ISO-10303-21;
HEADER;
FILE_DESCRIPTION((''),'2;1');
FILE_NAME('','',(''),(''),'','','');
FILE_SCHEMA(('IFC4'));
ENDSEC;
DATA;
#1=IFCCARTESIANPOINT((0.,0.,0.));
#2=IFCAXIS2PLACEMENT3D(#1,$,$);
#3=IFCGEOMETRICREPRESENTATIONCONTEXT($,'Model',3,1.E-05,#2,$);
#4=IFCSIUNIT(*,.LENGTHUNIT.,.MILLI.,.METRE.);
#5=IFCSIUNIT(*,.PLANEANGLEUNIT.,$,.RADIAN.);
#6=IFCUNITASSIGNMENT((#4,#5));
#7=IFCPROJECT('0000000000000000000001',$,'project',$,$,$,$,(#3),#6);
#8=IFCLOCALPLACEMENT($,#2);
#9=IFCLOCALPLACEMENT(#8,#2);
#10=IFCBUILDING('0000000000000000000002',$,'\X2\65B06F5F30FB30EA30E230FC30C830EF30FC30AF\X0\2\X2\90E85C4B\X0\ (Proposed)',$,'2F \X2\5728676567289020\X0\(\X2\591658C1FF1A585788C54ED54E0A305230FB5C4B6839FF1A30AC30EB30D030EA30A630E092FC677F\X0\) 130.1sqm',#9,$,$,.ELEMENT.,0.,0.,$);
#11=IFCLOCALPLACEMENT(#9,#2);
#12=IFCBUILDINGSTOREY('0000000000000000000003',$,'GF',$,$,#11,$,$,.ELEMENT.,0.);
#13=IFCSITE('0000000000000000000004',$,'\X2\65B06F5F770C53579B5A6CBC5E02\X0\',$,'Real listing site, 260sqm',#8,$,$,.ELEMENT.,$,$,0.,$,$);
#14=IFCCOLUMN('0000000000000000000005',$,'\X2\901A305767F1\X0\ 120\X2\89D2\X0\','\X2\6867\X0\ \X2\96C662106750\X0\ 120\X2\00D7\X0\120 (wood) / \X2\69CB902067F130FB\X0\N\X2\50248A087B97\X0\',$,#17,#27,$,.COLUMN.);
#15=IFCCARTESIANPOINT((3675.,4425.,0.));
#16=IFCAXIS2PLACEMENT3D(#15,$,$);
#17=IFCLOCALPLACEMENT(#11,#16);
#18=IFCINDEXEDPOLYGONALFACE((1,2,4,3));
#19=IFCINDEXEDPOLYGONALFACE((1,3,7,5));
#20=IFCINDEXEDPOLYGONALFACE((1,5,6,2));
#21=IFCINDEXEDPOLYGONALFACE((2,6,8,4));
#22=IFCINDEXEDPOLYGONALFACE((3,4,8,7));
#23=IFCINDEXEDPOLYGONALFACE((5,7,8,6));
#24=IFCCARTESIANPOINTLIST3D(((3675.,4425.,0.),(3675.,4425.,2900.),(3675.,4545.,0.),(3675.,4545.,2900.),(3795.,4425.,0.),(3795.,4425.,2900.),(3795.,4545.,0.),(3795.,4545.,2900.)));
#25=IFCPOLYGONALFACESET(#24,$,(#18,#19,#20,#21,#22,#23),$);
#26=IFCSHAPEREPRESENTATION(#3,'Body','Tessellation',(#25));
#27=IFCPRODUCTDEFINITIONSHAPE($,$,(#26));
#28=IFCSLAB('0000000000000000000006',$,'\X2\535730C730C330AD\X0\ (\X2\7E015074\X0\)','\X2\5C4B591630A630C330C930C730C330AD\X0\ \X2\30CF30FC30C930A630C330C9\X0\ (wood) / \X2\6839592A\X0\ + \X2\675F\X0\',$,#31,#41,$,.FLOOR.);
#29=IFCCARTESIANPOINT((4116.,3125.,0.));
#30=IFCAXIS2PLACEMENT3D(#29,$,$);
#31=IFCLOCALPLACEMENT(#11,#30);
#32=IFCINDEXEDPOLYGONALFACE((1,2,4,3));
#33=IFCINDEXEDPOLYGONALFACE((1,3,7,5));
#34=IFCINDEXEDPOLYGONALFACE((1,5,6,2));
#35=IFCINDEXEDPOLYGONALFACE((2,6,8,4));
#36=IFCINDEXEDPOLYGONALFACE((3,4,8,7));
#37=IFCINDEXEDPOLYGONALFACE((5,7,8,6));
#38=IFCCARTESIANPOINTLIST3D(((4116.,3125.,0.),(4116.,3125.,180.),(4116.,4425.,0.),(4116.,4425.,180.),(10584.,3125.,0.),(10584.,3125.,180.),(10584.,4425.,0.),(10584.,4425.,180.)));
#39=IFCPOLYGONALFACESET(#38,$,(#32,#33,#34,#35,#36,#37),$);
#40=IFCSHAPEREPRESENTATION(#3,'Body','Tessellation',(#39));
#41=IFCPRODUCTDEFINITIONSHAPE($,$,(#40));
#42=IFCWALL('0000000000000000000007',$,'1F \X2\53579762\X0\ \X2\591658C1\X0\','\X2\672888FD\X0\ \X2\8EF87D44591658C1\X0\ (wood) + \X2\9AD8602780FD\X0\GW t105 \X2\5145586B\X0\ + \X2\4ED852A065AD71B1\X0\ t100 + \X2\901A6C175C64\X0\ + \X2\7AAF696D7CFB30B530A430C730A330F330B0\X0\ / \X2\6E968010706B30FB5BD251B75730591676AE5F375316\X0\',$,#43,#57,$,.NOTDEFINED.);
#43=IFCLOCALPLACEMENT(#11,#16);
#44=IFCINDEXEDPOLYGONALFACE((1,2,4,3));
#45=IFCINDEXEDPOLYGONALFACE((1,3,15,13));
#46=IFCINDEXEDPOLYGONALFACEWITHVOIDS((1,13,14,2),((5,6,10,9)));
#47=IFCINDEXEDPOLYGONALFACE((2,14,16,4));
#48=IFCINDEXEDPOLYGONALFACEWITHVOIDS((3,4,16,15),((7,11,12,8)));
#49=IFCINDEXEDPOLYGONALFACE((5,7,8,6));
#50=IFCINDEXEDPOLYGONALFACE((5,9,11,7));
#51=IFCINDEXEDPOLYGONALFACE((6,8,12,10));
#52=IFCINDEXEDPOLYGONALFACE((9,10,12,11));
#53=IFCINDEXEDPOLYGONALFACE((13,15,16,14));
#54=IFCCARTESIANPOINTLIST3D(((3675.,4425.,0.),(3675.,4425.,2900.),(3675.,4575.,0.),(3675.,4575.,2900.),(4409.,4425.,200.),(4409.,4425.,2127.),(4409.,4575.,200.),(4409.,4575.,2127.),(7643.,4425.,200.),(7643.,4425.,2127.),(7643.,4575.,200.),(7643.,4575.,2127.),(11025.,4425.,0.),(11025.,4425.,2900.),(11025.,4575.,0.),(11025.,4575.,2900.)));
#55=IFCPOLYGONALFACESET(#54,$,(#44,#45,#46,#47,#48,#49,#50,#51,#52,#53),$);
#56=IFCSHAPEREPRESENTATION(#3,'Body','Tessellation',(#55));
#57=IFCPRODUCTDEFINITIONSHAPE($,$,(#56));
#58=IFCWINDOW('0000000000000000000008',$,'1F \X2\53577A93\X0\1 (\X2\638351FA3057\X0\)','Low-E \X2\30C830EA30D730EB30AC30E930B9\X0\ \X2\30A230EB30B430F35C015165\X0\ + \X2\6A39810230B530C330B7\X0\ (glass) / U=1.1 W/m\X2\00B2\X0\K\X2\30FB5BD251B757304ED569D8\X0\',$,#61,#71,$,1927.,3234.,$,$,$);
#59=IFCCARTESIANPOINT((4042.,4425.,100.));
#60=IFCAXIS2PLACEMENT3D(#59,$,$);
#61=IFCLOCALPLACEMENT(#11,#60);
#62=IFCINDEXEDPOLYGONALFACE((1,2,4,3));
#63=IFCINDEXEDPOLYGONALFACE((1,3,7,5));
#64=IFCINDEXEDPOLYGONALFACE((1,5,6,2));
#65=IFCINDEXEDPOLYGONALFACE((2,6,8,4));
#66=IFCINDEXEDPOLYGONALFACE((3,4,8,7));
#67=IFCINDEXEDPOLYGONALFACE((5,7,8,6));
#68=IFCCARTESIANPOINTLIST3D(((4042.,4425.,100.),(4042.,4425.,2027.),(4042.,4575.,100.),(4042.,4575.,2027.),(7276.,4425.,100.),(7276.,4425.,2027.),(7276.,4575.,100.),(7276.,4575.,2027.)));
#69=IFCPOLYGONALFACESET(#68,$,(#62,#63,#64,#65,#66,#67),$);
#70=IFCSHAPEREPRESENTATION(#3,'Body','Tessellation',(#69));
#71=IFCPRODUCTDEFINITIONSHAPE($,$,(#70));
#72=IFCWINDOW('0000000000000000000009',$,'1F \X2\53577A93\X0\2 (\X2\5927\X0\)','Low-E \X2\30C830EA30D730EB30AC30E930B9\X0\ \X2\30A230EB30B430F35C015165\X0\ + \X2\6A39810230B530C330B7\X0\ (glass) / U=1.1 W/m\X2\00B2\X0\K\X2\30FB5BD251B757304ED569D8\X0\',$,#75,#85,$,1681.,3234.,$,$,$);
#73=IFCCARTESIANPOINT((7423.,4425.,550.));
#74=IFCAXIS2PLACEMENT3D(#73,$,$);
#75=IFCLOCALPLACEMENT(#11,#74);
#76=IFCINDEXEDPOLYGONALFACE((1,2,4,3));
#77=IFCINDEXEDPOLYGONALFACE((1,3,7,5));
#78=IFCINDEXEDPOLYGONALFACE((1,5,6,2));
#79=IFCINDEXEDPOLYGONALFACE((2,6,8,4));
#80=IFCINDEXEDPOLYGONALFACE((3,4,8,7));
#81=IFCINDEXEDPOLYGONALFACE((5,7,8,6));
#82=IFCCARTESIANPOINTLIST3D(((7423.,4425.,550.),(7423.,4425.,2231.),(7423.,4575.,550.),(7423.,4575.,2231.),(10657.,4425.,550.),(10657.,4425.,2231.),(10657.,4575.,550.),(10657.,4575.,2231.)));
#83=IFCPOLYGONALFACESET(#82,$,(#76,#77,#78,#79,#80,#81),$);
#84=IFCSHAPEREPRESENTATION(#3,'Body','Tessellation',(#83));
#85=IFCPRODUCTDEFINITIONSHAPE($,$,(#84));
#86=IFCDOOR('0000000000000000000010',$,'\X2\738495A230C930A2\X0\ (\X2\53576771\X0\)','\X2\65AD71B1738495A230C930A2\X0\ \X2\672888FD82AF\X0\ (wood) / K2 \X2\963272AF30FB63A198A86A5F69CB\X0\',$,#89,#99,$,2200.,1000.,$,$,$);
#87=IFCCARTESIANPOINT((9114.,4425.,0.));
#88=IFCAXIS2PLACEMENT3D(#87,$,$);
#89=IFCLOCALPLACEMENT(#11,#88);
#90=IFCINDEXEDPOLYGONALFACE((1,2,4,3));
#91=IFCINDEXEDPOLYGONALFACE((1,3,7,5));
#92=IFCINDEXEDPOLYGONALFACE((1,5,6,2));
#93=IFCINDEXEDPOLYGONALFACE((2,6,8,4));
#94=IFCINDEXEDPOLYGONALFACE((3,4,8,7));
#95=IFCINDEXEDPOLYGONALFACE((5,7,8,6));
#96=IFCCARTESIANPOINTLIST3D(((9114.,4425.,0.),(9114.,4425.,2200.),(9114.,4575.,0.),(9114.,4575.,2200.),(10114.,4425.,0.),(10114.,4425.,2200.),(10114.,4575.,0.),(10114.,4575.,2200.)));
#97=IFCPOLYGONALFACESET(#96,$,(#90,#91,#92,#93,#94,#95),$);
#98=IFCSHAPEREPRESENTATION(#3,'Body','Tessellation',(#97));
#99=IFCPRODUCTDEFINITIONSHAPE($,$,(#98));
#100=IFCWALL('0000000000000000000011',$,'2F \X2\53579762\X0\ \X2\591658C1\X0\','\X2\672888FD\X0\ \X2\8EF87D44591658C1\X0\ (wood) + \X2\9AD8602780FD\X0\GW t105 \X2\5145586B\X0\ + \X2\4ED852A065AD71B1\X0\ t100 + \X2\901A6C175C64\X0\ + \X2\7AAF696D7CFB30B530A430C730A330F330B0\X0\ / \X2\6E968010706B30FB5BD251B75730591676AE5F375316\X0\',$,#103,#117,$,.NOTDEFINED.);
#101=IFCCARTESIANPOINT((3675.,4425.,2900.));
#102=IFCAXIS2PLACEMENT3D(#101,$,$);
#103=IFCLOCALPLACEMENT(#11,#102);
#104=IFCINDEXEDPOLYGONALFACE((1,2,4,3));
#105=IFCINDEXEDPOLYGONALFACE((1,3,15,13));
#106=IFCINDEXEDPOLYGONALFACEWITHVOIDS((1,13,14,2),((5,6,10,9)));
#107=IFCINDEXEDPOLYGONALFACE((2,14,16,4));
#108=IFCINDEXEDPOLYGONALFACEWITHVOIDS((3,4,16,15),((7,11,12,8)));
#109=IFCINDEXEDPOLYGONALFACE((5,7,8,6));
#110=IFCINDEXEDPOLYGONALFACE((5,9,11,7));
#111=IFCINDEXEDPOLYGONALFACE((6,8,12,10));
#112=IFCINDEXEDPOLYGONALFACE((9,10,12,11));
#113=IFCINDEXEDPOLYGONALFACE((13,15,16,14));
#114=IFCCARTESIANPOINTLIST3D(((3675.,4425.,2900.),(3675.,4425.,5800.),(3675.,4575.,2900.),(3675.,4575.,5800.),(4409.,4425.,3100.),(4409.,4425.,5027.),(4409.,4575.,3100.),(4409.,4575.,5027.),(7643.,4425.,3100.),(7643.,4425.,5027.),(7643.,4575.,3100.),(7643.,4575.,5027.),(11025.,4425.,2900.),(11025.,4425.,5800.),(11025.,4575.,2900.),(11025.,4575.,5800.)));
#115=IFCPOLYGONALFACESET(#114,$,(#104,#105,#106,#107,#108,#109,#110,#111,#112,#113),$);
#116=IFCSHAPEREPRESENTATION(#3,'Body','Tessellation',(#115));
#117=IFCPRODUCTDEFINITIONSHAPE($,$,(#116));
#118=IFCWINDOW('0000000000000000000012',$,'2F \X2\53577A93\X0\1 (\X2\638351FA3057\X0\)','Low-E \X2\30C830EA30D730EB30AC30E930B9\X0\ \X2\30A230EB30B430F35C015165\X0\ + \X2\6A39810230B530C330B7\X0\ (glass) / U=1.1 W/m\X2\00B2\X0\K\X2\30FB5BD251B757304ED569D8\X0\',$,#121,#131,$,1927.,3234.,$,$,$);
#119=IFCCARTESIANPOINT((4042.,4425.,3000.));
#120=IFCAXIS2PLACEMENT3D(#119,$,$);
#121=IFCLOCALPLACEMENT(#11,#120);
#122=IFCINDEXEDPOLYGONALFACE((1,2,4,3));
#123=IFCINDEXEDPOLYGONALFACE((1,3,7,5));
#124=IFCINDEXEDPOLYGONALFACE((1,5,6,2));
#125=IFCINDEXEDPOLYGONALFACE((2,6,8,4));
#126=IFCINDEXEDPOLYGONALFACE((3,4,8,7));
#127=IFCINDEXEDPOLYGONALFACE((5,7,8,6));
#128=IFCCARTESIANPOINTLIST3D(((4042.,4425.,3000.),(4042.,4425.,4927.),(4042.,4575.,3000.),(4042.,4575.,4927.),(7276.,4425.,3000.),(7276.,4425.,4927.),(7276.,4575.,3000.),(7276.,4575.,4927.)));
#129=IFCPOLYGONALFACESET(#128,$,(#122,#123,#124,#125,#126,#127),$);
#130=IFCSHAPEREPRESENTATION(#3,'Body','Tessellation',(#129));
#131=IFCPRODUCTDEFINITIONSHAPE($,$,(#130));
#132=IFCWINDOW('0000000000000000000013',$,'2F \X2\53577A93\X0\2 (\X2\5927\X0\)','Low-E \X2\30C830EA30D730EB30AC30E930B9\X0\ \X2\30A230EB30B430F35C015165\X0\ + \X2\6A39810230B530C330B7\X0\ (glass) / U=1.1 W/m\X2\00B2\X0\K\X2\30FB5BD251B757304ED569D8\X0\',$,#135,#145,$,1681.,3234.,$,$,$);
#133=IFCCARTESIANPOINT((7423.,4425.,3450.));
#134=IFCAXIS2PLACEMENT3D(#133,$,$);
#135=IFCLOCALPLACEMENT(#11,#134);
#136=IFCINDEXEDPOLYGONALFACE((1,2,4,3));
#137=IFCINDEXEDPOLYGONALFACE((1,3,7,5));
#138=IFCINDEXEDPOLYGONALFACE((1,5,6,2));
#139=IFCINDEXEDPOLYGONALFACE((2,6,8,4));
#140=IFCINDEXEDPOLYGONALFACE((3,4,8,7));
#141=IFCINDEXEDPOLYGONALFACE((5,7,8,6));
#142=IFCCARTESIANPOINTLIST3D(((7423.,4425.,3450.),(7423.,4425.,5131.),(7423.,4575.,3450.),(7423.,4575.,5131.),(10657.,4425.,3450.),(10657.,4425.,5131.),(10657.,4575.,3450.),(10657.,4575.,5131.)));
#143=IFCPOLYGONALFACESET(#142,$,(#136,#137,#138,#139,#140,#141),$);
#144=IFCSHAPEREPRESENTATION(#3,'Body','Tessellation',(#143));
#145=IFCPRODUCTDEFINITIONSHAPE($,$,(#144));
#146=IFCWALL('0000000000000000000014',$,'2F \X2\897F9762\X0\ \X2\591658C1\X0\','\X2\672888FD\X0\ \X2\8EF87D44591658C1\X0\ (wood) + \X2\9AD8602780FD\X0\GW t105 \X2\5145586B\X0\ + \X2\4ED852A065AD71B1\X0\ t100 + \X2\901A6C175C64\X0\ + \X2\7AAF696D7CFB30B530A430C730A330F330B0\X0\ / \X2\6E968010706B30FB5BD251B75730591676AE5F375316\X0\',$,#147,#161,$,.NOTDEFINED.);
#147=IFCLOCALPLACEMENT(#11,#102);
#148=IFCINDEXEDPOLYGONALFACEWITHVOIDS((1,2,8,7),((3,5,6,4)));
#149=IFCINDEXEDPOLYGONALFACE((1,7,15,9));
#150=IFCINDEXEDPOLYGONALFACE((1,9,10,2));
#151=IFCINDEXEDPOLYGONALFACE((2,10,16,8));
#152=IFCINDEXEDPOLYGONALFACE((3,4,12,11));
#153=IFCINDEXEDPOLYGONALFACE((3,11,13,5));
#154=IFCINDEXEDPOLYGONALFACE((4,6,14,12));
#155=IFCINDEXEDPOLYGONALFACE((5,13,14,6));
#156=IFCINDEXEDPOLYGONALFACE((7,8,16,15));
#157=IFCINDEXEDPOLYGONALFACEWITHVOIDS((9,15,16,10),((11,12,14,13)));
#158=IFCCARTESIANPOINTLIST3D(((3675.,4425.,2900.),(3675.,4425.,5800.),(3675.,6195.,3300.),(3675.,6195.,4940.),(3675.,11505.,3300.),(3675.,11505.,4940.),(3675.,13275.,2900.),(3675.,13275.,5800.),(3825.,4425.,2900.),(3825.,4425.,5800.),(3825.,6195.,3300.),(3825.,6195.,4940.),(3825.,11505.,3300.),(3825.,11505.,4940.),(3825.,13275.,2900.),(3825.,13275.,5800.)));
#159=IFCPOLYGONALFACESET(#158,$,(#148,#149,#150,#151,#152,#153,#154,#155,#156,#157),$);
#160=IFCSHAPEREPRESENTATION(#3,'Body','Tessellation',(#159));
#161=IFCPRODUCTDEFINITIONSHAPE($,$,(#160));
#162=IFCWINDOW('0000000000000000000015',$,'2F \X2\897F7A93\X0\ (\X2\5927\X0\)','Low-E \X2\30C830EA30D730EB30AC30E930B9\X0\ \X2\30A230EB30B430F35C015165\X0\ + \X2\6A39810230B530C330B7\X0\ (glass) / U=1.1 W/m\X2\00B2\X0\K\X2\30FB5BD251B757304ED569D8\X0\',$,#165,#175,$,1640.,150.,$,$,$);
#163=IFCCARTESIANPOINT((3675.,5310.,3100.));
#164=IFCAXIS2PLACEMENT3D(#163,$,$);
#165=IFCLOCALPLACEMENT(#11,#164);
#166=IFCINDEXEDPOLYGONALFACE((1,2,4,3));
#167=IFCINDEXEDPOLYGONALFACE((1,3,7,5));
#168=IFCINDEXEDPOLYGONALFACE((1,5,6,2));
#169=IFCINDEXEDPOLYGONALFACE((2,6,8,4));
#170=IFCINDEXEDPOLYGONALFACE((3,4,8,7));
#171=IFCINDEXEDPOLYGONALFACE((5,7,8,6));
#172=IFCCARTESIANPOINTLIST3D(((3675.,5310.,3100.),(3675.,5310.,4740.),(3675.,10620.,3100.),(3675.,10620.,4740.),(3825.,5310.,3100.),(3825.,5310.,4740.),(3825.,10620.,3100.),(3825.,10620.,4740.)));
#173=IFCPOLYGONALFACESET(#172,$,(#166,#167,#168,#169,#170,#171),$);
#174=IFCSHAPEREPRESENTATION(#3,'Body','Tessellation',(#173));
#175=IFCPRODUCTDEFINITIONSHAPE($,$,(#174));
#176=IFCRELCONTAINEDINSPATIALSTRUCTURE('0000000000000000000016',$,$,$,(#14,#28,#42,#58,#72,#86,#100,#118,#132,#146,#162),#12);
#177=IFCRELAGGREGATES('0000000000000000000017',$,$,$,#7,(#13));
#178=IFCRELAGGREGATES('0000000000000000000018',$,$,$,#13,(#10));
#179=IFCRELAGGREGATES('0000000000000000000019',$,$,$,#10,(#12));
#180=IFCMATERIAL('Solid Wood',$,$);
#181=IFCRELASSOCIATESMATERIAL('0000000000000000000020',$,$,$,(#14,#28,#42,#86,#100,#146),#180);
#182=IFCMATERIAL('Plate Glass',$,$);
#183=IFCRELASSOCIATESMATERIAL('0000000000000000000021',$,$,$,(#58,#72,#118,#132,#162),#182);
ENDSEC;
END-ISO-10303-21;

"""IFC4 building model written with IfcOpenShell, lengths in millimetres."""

from ifc_helpers import new_model, si_unit, frame, frame_2d, origin, place, context, project, spatial, rectangle, extrude, material, element, fill, save


model = new_model("IFC4")

# Units and contexts
model_context = context("Model", 3, precision=1e-05, world=origin())
ifc_project = project(units=[si_unit("LENGTHUNIT", "METRE", prefix="MILLI"), si_unit("PLANEANGLEUNIT", "RADIAN")], contexts=[model_context])

# Site, building, storey
site_placement = place(None, origin())
site = spatial("IfcSite", under=ifc_project, at=site_placement, Name="新潟県南魚沼市", ObjectType="Real listing site, 260sqm", CompositionType="ELEMENT", RefElevation=0.0)
building_placement = place(site_placement, origin())
building = spatial("IfcBuilding", under=site, at=building_placement, Name="新潟・リモートワーク2部屋 (Proposed)", ObjectType="2F 在来木造(外壁：塗装仕上げ・屋根：ガルバリウム鋼板) 130.1sqm", CompositionType="ELEMENT", ElevationOfRefHeight=0.0, ElevationOfTerrain=0.0)
storey_placement = place(building_placement, origin())
storey = spatial("IfcBuildingStorey", under=building, at=storey_placement, Name="GF", CompositionType="ELEMENT", Elevation=0.0)

# Column
ifc_material_1 = material(Name="Solid Wood")
column_placement = place(storey_placement, frame((3675.0, 4425.0, 0.0)))
element("IfcColumn", 1, at=column_placement, inside=storey, material=ifc_material_1, Name="通し柱 120角", Description="桧 集成材 120×120 (wood) / 構造柱・N値計算", PredefinedType="COLUMN", context=model_context, shape_type="SweptSolid", body=[
    extrude(rectangle(XDim=120.0, YDim=120.0, at=frame_2d((60.0, 60.0))), frame((3675.0, 4425.0, 0.0)), (0.0, 0.0, 1.0), 2900.0),
])

# Slab
slab_1_placement = place(storey_placement, frame((4116.0, 3125.0, 0.0)))
element("IfcSlab", 2, at=slab_1_placement, inside=storey, material=ifc_material_1, Name="南デッキ (縁側)", Description="屋外ウッドデッキ ハードウッド (wood) / 根太 + 束", PredefinedType="FLOOR", context=model_context, shape_type="SweptSolid", body=[
    extrude(rectangle(XDim=6468.0, YDim=1300.0, at=frame_2d((3234.0, 650.0))), frame((4116.0, 3125.0, 0.0)), (0.0, 0.0, 1.0), 180.0),
])

# Wall, openings, windows, door
wall_1_placement = place(storey_placement, frame((3675.0, 4425.0, 0.0)))
wall_1 = element("IfcWall", 3, at=wall_1_placement, inside=storey, material=ifc_material_1, Name="1F 南面 外壁", Description="木製 軸組外壁 (wood) + 高性能GW t105 充填 + 付加断熱 t100 + 通気層 + 窯業系サイディング / 準耐火・寒冷地外皮強化", PredefinedType="NOTDEFINED", context=model_context, shape_type="SweptSolid", body=[
    extrude(rectangle(XDim=7350.0, YDim=150.0, at=frame_2d((3675.0, 75.0))), frame((3675.0, 4425.0, 0.0)), (0.0, 0.0, 1.0), 2900.0),
])
opening_1_placement = place(storey_placement, frame((4042.0, 4425.0, 100.0)))
opening_1 = element("IfcOpeningElement", 4, at=opening_1_placement, cuts=wall_1, PredefinedType="NOTDEFINED", context=model_context, shape_type="SweptSolid", body=[
    extrude(rectangle(XDim=3234.0, YDim=150.0, at=frame_2d((1617.0, 75.0))), frame((4042.0, 4425.0, 100.0)), (0.0, 0.0, 1.0), 1927.0),
])
opening_2_placement = place(storey_placement, frame((7423.0, 4425.0, 550.0)))
opening_2 = element("IfcOpeningElement", 5, at=opening_2_placement, cuts=wall_1, PredefinedType="NOTDEFINED", context=model_context, shape_type="SweptSolid", body=[
    extrude(rectangle(XDim=3234.0, YDim=150.0, at=frame_2d((1617.0, 75.0))), frame((7423.0, 4425.0, 550.0)), (0.0, 0.0, 1.0), 1681.0),
])
opening_3_placement = place(storey_placement, frame((9114.0, 4425.0, 0.0)))
opening_3 = element("IfcOpeningElement", 6, at=opening_3_placement, cuts=wall_1, PredefinedType="NOTDEFINED", context=model_context, shape_type="SweptSolid", body=[
    extrude(rectangle(XDim=1000.0, YDim=150.0, at=frame_2d((500.0, 75.0))), frame((9114.0, 4425.0, 0.0)), (0.0, 0.0, 1.0), 2200.0),
])
ifc_material_2 = material(Name="Plate Glass")
window_1_placement = place(storey_placement, frame((4042.0, 4425.0, 100.0)))
window_1 = element("IfcWindow", 7, at=window_1_placement, inside=storey, material=ifc_material_2, Name="1F 南窓1 (掃出し)", Description="Low-E トリプルガラス アルゴン封入 + 樹脂サッシ (glass) / U=1.1 W/m²K・寒冷地仕様", OverallHeight=1927.0, OverallWidth=3234.0, context=model_context, shape_type="SweptSolid", body=[
    extrude(rectangle(XDim=3234.0, YDim=150.0, at=frame_2d((1617.0, 75.0))), frame((4042.0, 4425.0, 100.0)), (0.0, 0.0, 1.0), 1927.0),
])
fill(opening_1, window_1)
window_2_placement = place(storey_placement, frame((7423.0, 4425.0, 550.0)))
window_2 = element("IfcWindow", 8, at=window_2_placement, inside=storey, material=ifc_material_2, Name="1F 南窓2 (大)", Description="Low-E トリプルガラス アルゴン封入 + 樹脂サッシ (glass) / U=1.1 W/m²K・寒冷地仕様", OverallHeight=1681.0, OverallWidth=3234.0, context=model_context, shape_type="SweptSolid", body=[
    extrude(rectangle(XDim=3234.0, YDim=150.0, at=frame_2d((1617.0, 75.0))), frame((7423.0, 4425.0, 550.0)), (0.0, 0.0, 1.0), 1681.0),
])
fill(opening_2, window_2)
door_placement = place(storey_placement, frame((9114.0, 4425.0, 0.0)))
door = element("IfcDoor", 9, at=door_placement, inside=storey, material=ifc_material_1, Name="玄関ドア (南東)", Description="断熱玄関ドア 木製芯 (wood) / K2 防犯・採風機構", OverallHeight=2200.0, OverallWidth=1000.0, context=model_context, shape_type="SweptSolid", body=[
    extrude(rectangle(XDim=1000.0, YDim=150.0, at=frame_2d((500.0, 75.0))), frame((9114.0, 4425.0, 0.0)), (0.0, 0.0, 1.0), 2200.0),
])
fill(opening_3, door)

# Wall, openings, windows
wall_2_placement = place(storey_placement, frame((3675.0, 4425.0, 2900.0)))
wall_2 = element("IfcWall", 10, at=wall_2_placement, inside=storey, material=ifc_material_1, Name="2F 南面 外壁", Description="木製 軸組外壁 (wood) + 高性能GW t105 充填 + 付加断熱 t100 + 通気層 + 窯業系サイディング / 準耐火・寒冷地外皮強化", PredefinedType="NOTDEFINED", context=model_context, shape_type="SweptSolid", body=[
    extrude(rectangle(XDim=7350.0, YDim=150.0, at=frame_2d((3675.0, 75.0))), frame((3675.0, 4425.0, 2900.0)), (0.0, 0.0, 1.0), 2900.0),
])
opening_4_placement = place(storey_placement, frame((4042.0, 4425.0, 3000.0)))
opening_4 = element("IfcOpeningElement", 11, at=opening_4_placement, cuts=wall_2, PredefinedType="NOTDEFINED", context=model_context, shape_type="SweptSolid", body=[
    extrude(rectangle(XDim=3234.0, YDim=150.0, at=frame_2d((1617.0, 75.0))), frame((4042.0, 4425.0, 3000.0)), (0.0, 0.0, 1.0), 1927.0),
])
opening_5_placement = place(storey_placement, frame((7423.0, 4425.0, 3450.0)))
opening_5 = element("IfcOpeningElement", 12, at=opening_5_placement, cuts=wall_2, PredefinedType="NOTDEFINED", context=model_context, shape_type="SweptSolid", body=[
    extrude(rectangle(XDim=3234.0, YDim=150.0, at=frame_2d((1617.0, 75.0))), frame((7423.0, 4425.0, 3450.0)), (0.0, 0.0, 1.0), 1681.0),
])
window_3_placement = place(storey_placement, frame((4042.0, 4425.0, 3000.0)))
window_3 = element("IfcWindow", 13, at=window_3_placement, inside=storey, material=ifc_material_2, Name="2F 南窓1 (掃出し)", Description="Low-E トリプルガラス アルゴン封入 + 樹脂サッシ (glass) / U=1.1 W/m²K・寒冷地仕様", OverallHeight=1927.0, OverallWidth=3234.0, context=model_context, shape_type="SweptSolid", body=[
    extrude(rectangle(XDim=3234.0, YDim=150.0, at=frame_2d((1617.0, 75.0))), frame((4042.0, 4425.0, 3000.0)), (0.0, 0.0, 1.0), 1927.0),
])
fill(opening_4, window_3)
window_4_placement = place(storey_placement, frame((7423.0, 4425.0, 3450.0)))
window_4 = element("IfcWindow", 14, at=window_4_placement, inside=storey, material=ifc_material_2, Name="2F 南窓2 (大)", Description="Low-E トリプルガラス アルゴン封入 + 樹脂サッシ (glass) / U=1.1 W/m²K・寒冷地仕様", OverallHeight=1681.0, OverallWidth=3234.0, context=model_context, shape_type="SweptSolid", body=[
    extrude(rectangle(XDim=3234.0, YDim=150.0, at=frame_2d((1617.0, 75.0))), frame((7423.0, 4425.0, 3450.0)), (0.0, 0.0, 1.0), 1681.0),
])
fill(opening_5, window_4)

# Wall, opening, window
wall_3_placement = place(storey_placement, frame((3675.0, 4425.0, 2900.0)))
wall_3 = element("IfcWall", 15, at=wall_3_placement, inside=storey, material=ifc_material_1, Name="2F 西面 外壁", Description="木製 軸組外壁 (wood) + 高性能GW t105 充填 + 付加断熱 t100 + 通気層 + 窯業系サイディング / 準耐火・寒冷地外皮強化", PredefinedType="NOTDEFINED", context=model_context, shape_type="SweptSolid", body=[
    extrude(rectangle(XDim=150.0, YDim=8850.0, at=frame_2d((75.0, 4425.0))), frame((3675.0, 4425.0, 2900.0)), (0.0, 0.0, 1.0), 2900.0),
])
opening_6_placement = place(storey_placement, frame((3675.0, 5310.0, 3100.0)))
opening_6 = element("IfcOpeningElement", 16, at=opening_6_placement, cuts=wall_3, PredefinedType="NOTDEFINED", context=model_context, shape_type="SweptSolid", body=[
    extrude(rectangle(XDim=150.0, YDim=5310.0, at=frame_2d((75.0, 2655.0))), frame((3675.0, 5310.0, 3100.0)), (0.0, 0.0, 1.0), 1640.0),
])
window_5_placement = place(storey_placement, frame((3675.0, 5310.0, 3100.0)))
window_5 = element("IfcWindow", 17, at=window_5_placement, inside=storey, material=ifc_material_2, Name="2F 西窓 (大)", Description="Low-E トリプルガラス アルゴン封入 + 樹脂サッシ (glass) / U=1.1 W/m²K・寒冷地仕様", OverallHeight=1640.0, OverallWidth=150.0, context=model_context, shape_type="SweptSolid", body=[
    extrude(rectangle(XDim=150.0, YDim=5310.0, at=frame_2d((75.0, 2655.0))), frame((3675.0, 5310.0, 3100.0)), (0.0, 0.0, 1.0), 1640.0),
])
fill(opening_6, window_5)

save(model, "model.ifc")
